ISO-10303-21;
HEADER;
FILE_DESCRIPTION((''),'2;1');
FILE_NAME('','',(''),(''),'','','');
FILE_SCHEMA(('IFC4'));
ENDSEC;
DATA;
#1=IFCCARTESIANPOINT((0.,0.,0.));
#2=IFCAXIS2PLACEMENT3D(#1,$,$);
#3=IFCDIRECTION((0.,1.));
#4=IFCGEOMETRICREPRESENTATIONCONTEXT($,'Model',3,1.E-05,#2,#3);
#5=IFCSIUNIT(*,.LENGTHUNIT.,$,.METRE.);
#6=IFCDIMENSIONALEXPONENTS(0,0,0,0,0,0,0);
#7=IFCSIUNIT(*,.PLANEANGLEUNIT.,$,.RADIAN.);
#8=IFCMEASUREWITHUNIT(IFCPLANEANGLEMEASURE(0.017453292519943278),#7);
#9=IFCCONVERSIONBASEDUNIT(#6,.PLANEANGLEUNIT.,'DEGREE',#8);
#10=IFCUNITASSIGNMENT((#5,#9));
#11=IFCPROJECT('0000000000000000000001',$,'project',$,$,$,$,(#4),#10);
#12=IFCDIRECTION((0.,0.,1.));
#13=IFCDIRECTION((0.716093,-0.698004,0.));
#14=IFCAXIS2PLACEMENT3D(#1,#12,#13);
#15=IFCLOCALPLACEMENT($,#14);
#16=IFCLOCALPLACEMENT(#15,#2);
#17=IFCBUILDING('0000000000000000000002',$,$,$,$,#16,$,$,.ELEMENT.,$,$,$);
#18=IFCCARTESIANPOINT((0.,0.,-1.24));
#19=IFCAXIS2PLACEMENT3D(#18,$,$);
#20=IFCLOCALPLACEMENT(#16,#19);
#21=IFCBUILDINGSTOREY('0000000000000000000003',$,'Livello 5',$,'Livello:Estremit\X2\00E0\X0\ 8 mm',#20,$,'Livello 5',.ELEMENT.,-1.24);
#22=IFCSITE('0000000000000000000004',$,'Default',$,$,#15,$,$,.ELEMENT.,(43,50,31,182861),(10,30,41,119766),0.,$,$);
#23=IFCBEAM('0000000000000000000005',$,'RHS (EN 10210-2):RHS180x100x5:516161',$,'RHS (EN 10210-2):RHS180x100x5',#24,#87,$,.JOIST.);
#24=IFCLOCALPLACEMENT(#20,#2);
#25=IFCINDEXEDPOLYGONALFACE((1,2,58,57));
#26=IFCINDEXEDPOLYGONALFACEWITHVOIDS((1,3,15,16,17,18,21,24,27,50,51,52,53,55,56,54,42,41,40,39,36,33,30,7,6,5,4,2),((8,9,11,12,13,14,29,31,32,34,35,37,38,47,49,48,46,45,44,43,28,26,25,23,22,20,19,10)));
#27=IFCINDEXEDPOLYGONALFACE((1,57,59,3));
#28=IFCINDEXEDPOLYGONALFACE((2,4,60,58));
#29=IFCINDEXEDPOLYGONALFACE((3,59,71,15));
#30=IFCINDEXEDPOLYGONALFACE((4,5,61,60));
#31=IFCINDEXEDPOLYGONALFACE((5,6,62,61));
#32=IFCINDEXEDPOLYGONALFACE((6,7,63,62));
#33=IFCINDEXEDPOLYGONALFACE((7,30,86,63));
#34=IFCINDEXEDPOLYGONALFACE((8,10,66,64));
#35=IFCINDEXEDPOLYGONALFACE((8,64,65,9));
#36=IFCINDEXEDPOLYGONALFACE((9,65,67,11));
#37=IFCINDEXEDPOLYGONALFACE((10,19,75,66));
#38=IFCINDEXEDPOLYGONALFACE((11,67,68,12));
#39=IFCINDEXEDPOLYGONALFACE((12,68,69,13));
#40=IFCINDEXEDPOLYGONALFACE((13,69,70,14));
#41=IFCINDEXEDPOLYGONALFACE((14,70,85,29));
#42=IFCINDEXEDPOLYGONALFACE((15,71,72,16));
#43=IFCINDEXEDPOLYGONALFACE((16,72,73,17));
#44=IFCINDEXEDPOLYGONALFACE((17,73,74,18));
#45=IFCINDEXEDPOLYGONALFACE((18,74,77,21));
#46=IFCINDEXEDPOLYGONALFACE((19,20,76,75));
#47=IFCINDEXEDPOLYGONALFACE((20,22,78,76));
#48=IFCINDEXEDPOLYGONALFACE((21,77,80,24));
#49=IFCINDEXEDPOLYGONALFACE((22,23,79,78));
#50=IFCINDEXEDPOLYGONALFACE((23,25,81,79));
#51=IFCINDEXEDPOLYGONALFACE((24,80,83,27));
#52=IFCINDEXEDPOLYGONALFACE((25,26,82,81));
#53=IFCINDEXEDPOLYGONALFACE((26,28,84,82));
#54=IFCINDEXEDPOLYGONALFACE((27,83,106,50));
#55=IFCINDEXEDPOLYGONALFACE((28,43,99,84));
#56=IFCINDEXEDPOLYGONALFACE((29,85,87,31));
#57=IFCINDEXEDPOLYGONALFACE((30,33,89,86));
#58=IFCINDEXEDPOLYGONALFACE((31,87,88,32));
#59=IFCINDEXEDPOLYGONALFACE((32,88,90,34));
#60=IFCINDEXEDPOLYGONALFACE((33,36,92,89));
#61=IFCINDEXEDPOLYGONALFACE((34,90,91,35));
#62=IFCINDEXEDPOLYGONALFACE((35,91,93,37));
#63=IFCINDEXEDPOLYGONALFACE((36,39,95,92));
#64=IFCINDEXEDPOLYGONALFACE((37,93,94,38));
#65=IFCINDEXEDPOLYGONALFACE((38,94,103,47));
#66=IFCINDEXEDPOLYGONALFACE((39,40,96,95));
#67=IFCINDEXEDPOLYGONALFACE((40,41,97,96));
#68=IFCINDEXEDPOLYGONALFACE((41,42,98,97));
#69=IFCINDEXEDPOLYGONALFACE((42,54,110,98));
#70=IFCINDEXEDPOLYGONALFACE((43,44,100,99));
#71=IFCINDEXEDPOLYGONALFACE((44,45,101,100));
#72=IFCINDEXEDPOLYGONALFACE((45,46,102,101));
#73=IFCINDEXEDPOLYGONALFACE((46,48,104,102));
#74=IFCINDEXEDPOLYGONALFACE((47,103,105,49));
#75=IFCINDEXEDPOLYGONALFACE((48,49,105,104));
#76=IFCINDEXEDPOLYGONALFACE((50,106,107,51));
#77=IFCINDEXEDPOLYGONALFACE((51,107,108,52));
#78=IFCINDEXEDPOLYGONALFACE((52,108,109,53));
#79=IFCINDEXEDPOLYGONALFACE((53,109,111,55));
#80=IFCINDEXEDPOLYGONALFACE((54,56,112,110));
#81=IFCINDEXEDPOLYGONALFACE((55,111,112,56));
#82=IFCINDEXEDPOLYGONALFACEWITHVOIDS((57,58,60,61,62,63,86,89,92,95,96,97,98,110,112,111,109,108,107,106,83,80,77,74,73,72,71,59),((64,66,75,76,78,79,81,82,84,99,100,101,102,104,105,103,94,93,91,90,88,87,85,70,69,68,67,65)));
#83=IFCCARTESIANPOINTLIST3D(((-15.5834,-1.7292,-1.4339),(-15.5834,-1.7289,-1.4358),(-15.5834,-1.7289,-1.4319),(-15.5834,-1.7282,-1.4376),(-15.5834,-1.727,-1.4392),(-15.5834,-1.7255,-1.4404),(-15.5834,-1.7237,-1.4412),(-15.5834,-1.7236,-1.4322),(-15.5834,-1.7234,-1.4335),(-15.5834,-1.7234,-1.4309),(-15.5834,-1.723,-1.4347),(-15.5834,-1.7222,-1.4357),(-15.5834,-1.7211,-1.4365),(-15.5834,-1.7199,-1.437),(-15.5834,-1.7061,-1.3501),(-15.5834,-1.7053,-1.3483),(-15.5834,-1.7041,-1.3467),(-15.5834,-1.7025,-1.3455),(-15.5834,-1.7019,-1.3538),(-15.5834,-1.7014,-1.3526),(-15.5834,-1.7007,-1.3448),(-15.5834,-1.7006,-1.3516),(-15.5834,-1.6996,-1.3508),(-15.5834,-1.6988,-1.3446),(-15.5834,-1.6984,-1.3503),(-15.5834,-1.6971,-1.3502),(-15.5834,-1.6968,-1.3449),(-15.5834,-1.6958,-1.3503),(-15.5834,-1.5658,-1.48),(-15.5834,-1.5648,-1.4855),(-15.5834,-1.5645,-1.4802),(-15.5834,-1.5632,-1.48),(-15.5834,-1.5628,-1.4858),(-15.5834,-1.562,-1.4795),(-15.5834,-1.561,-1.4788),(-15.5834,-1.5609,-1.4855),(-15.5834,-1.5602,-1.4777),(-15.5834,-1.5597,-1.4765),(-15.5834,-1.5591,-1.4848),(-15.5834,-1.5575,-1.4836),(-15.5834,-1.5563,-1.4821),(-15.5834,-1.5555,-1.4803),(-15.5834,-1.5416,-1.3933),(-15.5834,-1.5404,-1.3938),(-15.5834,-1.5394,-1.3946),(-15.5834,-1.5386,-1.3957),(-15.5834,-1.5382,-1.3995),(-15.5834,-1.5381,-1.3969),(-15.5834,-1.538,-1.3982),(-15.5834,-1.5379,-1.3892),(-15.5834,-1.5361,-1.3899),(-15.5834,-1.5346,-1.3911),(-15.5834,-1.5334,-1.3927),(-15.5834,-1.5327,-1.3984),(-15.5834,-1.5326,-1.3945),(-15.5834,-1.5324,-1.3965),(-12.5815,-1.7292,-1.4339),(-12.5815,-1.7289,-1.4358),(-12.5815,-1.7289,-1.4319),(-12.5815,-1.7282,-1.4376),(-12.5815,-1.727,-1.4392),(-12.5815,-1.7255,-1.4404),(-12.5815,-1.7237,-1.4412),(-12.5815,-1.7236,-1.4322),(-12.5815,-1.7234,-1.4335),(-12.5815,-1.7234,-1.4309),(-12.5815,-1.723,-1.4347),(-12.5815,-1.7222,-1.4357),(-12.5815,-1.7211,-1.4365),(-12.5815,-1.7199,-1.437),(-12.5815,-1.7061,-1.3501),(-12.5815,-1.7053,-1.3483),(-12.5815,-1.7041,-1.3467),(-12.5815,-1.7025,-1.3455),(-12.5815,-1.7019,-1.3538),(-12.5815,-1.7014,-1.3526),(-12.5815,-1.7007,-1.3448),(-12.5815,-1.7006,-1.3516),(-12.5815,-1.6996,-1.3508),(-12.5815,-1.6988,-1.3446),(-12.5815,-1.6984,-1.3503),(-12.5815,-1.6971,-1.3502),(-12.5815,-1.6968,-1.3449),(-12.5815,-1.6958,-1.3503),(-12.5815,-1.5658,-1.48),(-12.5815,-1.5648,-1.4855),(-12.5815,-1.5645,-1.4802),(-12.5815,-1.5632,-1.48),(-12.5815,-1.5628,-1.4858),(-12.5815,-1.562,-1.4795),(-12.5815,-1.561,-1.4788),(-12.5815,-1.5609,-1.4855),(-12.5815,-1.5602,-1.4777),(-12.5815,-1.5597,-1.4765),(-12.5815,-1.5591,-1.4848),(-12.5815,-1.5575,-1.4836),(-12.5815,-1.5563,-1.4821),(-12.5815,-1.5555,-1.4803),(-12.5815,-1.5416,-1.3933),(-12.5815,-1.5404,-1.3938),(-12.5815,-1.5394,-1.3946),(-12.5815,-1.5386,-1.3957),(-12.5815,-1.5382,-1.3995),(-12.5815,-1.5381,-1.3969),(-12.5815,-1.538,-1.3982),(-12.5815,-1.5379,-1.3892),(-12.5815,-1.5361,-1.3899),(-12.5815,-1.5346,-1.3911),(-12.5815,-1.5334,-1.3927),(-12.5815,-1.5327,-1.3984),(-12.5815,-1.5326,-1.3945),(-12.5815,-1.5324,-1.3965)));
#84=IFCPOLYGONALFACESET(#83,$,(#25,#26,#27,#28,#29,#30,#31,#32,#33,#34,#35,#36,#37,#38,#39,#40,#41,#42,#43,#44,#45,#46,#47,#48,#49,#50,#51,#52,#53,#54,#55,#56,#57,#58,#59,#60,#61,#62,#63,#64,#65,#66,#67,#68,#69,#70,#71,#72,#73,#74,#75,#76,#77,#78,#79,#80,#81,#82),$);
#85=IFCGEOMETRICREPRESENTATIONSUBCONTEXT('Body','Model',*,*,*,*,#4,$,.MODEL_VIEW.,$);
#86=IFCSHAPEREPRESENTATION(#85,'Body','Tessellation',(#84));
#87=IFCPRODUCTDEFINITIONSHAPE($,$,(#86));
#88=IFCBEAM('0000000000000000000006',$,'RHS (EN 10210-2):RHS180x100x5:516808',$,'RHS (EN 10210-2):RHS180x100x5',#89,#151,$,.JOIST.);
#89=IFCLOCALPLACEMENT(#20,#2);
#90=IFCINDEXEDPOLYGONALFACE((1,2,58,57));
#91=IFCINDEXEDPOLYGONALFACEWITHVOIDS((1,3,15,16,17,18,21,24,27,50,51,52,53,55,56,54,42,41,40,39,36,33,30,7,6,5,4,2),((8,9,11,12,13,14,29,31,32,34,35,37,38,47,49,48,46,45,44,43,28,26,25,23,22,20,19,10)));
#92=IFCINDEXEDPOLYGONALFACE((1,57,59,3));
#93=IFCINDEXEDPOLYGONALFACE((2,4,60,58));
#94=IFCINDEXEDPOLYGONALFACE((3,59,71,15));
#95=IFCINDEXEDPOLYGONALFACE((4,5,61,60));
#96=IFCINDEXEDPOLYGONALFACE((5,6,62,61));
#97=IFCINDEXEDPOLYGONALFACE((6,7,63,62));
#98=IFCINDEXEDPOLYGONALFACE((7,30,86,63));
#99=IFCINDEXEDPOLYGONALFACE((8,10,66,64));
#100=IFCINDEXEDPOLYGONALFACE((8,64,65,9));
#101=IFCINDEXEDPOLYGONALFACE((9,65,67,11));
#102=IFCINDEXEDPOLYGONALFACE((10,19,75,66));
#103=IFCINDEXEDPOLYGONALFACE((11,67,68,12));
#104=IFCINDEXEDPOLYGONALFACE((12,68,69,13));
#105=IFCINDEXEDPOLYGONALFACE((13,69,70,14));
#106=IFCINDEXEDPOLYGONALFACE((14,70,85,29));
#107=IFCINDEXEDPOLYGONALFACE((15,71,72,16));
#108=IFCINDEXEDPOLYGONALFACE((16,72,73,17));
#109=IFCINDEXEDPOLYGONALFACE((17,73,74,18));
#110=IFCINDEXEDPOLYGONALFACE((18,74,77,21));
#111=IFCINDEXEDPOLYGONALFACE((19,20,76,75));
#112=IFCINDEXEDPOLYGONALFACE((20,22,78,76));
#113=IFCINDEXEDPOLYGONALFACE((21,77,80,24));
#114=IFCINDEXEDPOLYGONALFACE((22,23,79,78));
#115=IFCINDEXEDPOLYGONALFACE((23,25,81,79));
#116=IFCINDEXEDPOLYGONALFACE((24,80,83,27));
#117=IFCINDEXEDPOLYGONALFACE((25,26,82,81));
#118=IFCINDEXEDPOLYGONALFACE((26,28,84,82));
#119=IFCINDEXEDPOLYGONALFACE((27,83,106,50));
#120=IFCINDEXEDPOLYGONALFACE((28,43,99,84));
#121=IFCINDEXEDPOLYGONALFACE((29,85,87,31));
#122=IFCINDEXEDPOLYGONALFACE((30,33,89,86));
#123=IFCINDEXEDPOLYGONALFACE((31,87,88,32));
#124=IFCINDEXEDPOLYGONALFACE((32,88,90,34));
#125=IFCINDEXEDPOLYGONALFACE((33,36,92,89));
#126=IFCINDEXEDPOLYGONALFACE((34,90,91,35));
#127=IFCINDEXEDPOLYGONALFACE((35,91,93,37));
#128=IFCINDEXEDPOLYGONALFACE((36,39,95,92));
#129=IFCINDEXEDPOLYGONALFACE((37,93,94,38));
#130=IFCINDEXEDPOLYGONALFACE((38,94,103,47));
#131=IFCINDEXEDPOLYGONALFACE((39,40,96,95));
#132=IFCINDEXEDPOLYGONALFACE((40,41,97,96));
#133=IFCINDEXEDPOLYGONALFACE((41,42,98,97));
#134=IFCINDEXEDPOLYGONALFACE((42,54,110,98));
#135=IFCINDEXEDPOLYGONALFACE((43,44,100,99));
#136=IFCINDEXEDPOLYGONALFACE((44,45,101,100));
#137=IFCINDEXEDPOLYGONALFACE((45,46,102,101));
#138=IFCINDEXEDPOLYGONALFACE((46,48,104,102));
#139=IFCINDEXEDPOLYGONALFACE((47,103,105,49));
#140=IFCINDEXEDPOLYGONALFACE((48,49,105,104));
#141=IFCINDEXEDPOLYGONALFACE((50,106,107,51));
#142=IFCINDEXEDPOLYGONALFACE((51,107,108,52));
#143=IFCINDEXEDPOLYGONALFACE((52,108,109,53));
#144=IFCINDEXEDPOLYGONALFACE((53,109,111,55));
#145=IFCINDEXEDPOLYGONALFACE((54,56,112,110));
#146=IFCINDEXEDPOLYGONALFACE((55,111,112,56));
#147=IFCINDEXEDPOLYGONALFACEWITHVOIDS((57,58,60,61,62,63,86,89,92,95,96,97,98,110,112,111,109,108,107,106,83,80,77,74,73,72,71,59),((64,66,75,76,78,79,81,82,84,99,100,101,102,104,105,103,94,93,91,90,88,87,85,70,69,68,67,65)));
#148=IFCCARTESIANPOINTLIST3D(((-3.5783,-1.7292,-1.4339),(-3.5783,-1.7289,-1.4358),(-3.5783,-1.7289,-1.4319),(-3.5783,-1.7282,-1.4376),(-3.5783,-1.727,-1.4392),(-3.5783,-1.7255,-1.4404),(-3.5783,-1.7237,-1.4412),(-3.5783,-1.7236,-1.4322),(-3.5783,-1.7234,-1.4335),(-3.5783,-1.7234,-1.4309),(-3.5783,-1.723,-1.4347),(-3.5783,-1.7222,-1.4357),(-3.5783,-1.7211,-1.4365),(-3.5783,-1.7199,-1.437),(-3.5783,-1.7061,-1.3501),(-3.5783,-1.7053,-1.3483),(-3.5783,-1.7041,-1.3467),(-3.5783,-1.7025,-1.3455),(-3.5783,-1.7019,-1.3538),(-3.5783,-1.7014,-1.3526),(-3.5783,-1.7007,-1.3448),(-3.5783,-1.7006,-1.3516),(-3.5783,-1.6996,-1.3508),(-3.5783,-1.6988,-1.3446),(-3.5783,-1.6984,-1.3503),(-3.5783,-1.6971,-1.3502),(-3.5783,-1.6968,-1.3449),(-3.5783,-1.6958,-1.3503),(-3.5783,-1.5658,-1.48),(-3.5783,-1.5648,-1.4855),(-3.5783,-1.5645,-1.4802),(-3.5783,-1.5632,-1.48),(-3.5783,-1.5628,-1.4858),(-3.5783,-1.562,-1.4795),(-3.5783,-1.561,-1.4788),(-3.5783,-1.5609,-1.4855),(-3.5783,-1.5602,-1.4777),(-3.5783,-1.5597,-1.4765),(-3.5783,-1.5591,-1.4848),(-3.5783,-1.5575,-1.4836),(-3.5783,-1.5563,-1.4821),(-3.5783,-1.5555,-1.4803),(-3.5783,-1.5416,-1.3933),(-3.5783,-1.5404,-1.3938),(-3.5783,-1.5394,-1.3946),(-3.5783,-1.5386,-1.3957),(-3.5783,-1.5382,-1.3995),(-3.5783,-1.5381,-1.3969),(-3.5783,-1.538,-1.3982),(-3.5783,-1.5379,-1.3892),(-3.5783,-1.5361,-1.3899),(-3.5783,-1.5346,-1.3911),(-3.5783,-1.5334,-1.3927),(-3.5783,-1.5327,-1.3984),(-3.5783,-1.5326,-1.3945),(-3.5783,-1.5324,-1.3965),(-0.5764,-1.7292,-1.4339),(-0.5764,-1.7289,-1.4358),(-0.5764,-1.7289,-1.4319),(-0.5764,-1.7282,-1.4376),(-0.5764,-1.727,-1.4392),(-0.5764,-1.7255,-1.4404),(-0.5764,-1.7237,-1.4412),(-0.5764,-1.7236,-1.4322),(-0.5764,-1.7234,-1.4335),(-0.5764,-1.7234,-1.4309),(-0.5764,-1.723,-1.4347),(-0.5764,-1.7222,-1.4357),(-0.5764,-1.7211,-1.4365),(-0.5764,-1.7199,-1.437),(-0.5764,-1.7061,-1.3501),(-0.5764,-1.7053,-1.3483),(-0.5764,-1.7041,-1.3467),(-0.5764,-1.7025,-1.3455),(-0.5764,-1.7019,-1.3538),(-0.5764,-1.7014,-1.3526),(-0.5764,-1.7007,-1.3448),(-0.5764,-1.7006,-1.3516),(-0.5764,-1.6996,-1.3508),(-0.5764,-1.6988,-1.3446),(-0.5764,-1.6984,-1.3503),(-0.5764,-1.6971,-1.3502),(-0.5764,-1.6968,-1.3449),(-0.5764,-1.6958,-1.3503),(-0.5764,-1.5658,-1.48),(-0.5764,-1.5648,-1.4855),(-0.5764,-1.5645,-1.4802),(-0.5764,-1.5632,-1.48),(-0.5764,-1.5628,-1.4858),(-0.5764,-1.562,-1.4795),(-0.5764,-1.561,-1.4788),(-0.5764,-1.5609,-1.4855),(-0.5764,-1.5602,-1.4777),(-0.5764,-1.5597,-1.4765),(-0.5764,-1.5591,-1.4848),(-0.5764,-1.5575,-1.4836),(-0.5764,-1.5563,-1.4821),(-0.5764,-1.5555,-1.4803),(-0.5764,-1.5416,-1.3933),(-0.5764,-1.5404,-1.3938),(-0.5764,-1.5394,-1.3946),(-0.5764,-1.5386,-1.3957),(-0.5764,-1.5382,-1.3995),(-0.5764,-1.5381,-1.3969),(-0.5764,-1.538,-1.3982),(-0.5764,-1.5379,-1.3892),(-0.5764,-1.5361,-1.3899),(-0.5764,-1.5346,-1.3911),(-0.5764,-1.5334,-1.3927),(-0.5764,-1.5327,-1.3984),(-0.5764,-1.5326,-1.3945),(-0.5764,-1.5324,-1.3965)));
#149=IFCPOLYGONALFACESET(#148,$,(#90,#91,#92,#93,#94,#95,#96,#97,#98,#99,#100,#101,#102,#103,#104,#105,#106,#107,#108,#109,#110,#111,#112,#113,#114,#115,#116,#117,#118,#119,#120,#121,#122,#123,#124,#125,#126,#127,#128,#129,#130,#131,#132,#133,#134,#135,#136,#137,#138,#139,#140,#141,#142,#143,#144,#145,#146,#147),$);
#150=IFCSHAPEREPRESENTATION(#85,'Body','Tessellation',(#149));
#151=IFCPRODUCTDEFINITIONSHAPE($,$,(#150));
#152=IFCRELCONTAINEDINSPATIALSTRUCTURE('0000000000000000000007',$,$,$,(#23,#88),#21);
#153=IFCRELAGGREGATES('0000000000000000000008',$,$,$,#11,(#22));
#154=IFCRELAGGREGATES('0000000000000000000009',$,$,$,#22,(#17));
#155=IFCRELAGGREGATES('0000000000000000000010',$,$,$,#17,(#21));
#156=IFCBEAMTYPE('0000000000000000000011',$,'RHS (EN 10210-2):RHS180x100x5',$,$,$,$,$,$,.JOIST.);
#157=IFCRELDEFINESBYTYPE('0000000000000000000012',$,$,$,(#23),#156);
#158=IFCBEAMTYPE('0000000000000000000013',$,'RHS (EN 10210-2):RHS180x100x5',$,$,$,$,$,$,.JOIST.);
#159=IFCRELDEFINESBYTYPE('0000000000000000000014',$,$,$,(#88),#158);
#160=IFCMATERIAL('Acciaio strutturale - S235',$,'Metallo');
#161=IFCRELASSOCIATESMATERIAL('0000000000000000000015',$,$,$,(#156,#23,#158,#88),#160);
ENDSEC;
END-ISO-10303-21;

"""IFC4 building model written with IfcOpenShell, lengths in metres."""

from ifc_helpers import new_model, entity, si_unit, converted_unit, direction, frame, origin, place, context, subcontext, project, spatial, line, arc, indexed_curve, outline, extrude, source, transform, mapped, material, type_object, type_shapes, element, save


model = new_model("IFC4")

# Units and contexts
model_context = context("Model", 3, precision=1e-05, world=origin(), true_north=direction((0.0, 1.0)))
body_context = subcontext(model_context, "Body", "Model", "MODEL_VIEW")
ifc_project = project(units=[si_unit("LENGTHUNIT", "METRE"), converted_unit("PLANEANGLEUNIT", "DEGREE", entity("IfcPlaneAngleMeasure", 0.017453292519943278), si_unit("PLANEANGLEUNIT", "RADIAN"), dimensions=[0, 0, 0, 0, 0, 0, 0])], contexts=[model_context])

# Site, building, storey
site_placement = place(None, frame((0.0, 0.0, 0.0), z_axis=(0.0, 0.0, 1.0), x_axis=(0.716093, -0.698004, 0.0)))
site = spatial("IfcSite", under=ifc_project, at=site_placement, Name="Default", CompositionType="ELEMENT", RefLatitude=(43, 50, 31, 182861), RefLongitude=(10, 30, 41, 119766), RefElevation=0.0)
building_placement = place(site_placement, origin())
building = spatial("IfcBuilding", under=site, at=building_placement, CompositionType="ELEMENT")
storey_placement = place(building_placement, frame((0.0, 0.0, -1.24)))
storey = spatial("IfcBuildingStorey", under=building, at=storey_placement, Name="Livello 5", ObjectType="Livello:Estremità 8 mm", LongName="Livello 5", CompositionType="ELEMENT", Elevation=-1.24)

# Beams
ifc_material = material(Name="Acciaio strutturale - S235", Category="Metallo")
beam_type_1 = type_object("IfcBeamType", Name="RHS (EN 10210-2):RHS180x100x5", PredefinedType="JOIST", material=ifc_material)
shared_shape_1 = source(origin(), body_context, "Body", "SweptSolid", [
    extrude(outline(indexed_curve([(-0.05, -0.0825), (-0.0478, -0.0878), (-0.0425, -0.09), (0.0425, -0.09), (0.0478, -0.0878), (0.05, -0.0825), (0.05, 0.0825), (0.0478, 0.0878), (0.0425, 0.09), (-0.0425, 0.09), (-0.0478, 0.0878), (-0.05, 0.0825)], segments=[arc(1, 2, 3), line(3, 4), arc(4, 5, 6), line(6, 7), arc(7, 8, 9), line(9, 10), arc(10, 11, 12), line(12, 1)], self_intersect=False), holes=[indexed_curve([(0.04, -0.085), (-0.04, -0.085), (-0.0435, -0.0835), (-0.045, -0.08), (-0.045, 0.08), (-0.0435, 0.0835), (-0.04, 0.085), (0.04, 0.085), (0.0435, 0.0835), (0.045, 0.08), (0.045, -0.08), (0.0435, -0.0835)], segments=[line(1, 2), arc(2, 3, 4), line(4, 5), arc(5, 6, 7), line(7, 8), arc(8, 9, 10), line(10, 11), arc(11, 12, 1)], self_intersect=False)]), frame((-1.501, 0.0, 0.0), z_axis=(1.0, 0.0, 0.0), x_axis=(0.0, -1.0, 0.0)), (0.0, 0.0, 1.0), 3.0019),
])
type_shapes(beam_type_1, [shared_shape_1])
beam_1_placement = place(storey_placement, frame((-14.0824, -1.6308, -1.4152), z_axis=(0.0, 0.963256, -0.268584), x_axis=(-1.0, 0.0, 0.0)))
element("IfcBeam", 1, at=beam_1_placement, inside=storey, type_object=beam_type_1, material=ifc_material, Name="RHS (EN 10210-2):RHS180x100x5:516161", ObjectType="RHS (EN 10210-2):RHS180x100x5", PredefinedType="JOIST", context=body_context, shape_type="MappedRepresentation", body=[
    mapped(shared_shape_1, transform((0.0, 0.0, 0.0), scale=1.0)),
])
beam_type_2 = type_object("IfcBeamType", Name="RHS (EN 10210-2):RHS180x100x5", PredefinedType="JOIST", material=ifc_material)
shared_shape_2 = source(origin(), body_context, "Body", "SweptSolid", [
    extrude(outline(indexed_curve([(-0.05, -0.0825), (-0.0478, -0.0878), (-0.0425, -0.09), (0.0425, -0.09), (0.0478, -0.0878), (0.05, -0.0825), (0.05, 0.0825), (0.0478, 0.0878), (0.0425, 0.09), (-0.0425, 0.09), (-0.0478, 0.0878), (-0.05, 0.0825)], segments=[arc(1, 2, 3), line(3, 4), arc(4, 5, 6), line(6, 7), arc(7, 8, 9), line(9, 10), arc(10, 11, 12), line(12, 1)], self_intersect=False), holes=[indexed_curve([(0.04, -0.085), (-0.04, -0.085), (-0.0435, -0.0835), (-0.045, -0.08), (-0.045, 0.08), (-0.0435, 0.0835), (-0.04, 0.085), (0.04, 0.085), (0.0435, 0.0835), (0.045, 0.08), (0.045, -0.08), (0.0435, -0.0835)], segments=[line(1, 2), arc(2, 3, 4), line(4, 5), arc(5, 6, 7), line(7, 8), arc(8, 9, 10), line(10, 11), arc(11, 12, 1)], self_intersect=False)]), frame((-1.501, 0.0, 0.0), z_axis=(1.0, 0.0, 0.0), x_axis=(0.0, -1.0, 0.0)), (0.0, 0.0, 1.0), 3.0019),
])
type_shapes(beam_type_2, [shared_shape_2])
beam_2_placement = place(storey_placement, frame((-2.0774, -1.6308, -1.4152), z_axis=(0.0, 0.963256, -0.268584), x_axis=(-1.0, 0.0, 0.0)))
element("IfcBeam", 2, at=beam_2_placement, inside=storey, type_object=beam_type_2, material=ifc_material, Name="RHS (EN 10210-2):RHS180x100x5:516808", ObjectType="RHS (EN 10210-2):RHS180x100x5", PredefinedType="JOIST", context=body_context, shape_type="MappedRepresentation", body=[
    mapped(shared_shape_2, transform((0.0, 0.0, 0.0), scale=1.0)),
])

save(model, "model.ifc")
